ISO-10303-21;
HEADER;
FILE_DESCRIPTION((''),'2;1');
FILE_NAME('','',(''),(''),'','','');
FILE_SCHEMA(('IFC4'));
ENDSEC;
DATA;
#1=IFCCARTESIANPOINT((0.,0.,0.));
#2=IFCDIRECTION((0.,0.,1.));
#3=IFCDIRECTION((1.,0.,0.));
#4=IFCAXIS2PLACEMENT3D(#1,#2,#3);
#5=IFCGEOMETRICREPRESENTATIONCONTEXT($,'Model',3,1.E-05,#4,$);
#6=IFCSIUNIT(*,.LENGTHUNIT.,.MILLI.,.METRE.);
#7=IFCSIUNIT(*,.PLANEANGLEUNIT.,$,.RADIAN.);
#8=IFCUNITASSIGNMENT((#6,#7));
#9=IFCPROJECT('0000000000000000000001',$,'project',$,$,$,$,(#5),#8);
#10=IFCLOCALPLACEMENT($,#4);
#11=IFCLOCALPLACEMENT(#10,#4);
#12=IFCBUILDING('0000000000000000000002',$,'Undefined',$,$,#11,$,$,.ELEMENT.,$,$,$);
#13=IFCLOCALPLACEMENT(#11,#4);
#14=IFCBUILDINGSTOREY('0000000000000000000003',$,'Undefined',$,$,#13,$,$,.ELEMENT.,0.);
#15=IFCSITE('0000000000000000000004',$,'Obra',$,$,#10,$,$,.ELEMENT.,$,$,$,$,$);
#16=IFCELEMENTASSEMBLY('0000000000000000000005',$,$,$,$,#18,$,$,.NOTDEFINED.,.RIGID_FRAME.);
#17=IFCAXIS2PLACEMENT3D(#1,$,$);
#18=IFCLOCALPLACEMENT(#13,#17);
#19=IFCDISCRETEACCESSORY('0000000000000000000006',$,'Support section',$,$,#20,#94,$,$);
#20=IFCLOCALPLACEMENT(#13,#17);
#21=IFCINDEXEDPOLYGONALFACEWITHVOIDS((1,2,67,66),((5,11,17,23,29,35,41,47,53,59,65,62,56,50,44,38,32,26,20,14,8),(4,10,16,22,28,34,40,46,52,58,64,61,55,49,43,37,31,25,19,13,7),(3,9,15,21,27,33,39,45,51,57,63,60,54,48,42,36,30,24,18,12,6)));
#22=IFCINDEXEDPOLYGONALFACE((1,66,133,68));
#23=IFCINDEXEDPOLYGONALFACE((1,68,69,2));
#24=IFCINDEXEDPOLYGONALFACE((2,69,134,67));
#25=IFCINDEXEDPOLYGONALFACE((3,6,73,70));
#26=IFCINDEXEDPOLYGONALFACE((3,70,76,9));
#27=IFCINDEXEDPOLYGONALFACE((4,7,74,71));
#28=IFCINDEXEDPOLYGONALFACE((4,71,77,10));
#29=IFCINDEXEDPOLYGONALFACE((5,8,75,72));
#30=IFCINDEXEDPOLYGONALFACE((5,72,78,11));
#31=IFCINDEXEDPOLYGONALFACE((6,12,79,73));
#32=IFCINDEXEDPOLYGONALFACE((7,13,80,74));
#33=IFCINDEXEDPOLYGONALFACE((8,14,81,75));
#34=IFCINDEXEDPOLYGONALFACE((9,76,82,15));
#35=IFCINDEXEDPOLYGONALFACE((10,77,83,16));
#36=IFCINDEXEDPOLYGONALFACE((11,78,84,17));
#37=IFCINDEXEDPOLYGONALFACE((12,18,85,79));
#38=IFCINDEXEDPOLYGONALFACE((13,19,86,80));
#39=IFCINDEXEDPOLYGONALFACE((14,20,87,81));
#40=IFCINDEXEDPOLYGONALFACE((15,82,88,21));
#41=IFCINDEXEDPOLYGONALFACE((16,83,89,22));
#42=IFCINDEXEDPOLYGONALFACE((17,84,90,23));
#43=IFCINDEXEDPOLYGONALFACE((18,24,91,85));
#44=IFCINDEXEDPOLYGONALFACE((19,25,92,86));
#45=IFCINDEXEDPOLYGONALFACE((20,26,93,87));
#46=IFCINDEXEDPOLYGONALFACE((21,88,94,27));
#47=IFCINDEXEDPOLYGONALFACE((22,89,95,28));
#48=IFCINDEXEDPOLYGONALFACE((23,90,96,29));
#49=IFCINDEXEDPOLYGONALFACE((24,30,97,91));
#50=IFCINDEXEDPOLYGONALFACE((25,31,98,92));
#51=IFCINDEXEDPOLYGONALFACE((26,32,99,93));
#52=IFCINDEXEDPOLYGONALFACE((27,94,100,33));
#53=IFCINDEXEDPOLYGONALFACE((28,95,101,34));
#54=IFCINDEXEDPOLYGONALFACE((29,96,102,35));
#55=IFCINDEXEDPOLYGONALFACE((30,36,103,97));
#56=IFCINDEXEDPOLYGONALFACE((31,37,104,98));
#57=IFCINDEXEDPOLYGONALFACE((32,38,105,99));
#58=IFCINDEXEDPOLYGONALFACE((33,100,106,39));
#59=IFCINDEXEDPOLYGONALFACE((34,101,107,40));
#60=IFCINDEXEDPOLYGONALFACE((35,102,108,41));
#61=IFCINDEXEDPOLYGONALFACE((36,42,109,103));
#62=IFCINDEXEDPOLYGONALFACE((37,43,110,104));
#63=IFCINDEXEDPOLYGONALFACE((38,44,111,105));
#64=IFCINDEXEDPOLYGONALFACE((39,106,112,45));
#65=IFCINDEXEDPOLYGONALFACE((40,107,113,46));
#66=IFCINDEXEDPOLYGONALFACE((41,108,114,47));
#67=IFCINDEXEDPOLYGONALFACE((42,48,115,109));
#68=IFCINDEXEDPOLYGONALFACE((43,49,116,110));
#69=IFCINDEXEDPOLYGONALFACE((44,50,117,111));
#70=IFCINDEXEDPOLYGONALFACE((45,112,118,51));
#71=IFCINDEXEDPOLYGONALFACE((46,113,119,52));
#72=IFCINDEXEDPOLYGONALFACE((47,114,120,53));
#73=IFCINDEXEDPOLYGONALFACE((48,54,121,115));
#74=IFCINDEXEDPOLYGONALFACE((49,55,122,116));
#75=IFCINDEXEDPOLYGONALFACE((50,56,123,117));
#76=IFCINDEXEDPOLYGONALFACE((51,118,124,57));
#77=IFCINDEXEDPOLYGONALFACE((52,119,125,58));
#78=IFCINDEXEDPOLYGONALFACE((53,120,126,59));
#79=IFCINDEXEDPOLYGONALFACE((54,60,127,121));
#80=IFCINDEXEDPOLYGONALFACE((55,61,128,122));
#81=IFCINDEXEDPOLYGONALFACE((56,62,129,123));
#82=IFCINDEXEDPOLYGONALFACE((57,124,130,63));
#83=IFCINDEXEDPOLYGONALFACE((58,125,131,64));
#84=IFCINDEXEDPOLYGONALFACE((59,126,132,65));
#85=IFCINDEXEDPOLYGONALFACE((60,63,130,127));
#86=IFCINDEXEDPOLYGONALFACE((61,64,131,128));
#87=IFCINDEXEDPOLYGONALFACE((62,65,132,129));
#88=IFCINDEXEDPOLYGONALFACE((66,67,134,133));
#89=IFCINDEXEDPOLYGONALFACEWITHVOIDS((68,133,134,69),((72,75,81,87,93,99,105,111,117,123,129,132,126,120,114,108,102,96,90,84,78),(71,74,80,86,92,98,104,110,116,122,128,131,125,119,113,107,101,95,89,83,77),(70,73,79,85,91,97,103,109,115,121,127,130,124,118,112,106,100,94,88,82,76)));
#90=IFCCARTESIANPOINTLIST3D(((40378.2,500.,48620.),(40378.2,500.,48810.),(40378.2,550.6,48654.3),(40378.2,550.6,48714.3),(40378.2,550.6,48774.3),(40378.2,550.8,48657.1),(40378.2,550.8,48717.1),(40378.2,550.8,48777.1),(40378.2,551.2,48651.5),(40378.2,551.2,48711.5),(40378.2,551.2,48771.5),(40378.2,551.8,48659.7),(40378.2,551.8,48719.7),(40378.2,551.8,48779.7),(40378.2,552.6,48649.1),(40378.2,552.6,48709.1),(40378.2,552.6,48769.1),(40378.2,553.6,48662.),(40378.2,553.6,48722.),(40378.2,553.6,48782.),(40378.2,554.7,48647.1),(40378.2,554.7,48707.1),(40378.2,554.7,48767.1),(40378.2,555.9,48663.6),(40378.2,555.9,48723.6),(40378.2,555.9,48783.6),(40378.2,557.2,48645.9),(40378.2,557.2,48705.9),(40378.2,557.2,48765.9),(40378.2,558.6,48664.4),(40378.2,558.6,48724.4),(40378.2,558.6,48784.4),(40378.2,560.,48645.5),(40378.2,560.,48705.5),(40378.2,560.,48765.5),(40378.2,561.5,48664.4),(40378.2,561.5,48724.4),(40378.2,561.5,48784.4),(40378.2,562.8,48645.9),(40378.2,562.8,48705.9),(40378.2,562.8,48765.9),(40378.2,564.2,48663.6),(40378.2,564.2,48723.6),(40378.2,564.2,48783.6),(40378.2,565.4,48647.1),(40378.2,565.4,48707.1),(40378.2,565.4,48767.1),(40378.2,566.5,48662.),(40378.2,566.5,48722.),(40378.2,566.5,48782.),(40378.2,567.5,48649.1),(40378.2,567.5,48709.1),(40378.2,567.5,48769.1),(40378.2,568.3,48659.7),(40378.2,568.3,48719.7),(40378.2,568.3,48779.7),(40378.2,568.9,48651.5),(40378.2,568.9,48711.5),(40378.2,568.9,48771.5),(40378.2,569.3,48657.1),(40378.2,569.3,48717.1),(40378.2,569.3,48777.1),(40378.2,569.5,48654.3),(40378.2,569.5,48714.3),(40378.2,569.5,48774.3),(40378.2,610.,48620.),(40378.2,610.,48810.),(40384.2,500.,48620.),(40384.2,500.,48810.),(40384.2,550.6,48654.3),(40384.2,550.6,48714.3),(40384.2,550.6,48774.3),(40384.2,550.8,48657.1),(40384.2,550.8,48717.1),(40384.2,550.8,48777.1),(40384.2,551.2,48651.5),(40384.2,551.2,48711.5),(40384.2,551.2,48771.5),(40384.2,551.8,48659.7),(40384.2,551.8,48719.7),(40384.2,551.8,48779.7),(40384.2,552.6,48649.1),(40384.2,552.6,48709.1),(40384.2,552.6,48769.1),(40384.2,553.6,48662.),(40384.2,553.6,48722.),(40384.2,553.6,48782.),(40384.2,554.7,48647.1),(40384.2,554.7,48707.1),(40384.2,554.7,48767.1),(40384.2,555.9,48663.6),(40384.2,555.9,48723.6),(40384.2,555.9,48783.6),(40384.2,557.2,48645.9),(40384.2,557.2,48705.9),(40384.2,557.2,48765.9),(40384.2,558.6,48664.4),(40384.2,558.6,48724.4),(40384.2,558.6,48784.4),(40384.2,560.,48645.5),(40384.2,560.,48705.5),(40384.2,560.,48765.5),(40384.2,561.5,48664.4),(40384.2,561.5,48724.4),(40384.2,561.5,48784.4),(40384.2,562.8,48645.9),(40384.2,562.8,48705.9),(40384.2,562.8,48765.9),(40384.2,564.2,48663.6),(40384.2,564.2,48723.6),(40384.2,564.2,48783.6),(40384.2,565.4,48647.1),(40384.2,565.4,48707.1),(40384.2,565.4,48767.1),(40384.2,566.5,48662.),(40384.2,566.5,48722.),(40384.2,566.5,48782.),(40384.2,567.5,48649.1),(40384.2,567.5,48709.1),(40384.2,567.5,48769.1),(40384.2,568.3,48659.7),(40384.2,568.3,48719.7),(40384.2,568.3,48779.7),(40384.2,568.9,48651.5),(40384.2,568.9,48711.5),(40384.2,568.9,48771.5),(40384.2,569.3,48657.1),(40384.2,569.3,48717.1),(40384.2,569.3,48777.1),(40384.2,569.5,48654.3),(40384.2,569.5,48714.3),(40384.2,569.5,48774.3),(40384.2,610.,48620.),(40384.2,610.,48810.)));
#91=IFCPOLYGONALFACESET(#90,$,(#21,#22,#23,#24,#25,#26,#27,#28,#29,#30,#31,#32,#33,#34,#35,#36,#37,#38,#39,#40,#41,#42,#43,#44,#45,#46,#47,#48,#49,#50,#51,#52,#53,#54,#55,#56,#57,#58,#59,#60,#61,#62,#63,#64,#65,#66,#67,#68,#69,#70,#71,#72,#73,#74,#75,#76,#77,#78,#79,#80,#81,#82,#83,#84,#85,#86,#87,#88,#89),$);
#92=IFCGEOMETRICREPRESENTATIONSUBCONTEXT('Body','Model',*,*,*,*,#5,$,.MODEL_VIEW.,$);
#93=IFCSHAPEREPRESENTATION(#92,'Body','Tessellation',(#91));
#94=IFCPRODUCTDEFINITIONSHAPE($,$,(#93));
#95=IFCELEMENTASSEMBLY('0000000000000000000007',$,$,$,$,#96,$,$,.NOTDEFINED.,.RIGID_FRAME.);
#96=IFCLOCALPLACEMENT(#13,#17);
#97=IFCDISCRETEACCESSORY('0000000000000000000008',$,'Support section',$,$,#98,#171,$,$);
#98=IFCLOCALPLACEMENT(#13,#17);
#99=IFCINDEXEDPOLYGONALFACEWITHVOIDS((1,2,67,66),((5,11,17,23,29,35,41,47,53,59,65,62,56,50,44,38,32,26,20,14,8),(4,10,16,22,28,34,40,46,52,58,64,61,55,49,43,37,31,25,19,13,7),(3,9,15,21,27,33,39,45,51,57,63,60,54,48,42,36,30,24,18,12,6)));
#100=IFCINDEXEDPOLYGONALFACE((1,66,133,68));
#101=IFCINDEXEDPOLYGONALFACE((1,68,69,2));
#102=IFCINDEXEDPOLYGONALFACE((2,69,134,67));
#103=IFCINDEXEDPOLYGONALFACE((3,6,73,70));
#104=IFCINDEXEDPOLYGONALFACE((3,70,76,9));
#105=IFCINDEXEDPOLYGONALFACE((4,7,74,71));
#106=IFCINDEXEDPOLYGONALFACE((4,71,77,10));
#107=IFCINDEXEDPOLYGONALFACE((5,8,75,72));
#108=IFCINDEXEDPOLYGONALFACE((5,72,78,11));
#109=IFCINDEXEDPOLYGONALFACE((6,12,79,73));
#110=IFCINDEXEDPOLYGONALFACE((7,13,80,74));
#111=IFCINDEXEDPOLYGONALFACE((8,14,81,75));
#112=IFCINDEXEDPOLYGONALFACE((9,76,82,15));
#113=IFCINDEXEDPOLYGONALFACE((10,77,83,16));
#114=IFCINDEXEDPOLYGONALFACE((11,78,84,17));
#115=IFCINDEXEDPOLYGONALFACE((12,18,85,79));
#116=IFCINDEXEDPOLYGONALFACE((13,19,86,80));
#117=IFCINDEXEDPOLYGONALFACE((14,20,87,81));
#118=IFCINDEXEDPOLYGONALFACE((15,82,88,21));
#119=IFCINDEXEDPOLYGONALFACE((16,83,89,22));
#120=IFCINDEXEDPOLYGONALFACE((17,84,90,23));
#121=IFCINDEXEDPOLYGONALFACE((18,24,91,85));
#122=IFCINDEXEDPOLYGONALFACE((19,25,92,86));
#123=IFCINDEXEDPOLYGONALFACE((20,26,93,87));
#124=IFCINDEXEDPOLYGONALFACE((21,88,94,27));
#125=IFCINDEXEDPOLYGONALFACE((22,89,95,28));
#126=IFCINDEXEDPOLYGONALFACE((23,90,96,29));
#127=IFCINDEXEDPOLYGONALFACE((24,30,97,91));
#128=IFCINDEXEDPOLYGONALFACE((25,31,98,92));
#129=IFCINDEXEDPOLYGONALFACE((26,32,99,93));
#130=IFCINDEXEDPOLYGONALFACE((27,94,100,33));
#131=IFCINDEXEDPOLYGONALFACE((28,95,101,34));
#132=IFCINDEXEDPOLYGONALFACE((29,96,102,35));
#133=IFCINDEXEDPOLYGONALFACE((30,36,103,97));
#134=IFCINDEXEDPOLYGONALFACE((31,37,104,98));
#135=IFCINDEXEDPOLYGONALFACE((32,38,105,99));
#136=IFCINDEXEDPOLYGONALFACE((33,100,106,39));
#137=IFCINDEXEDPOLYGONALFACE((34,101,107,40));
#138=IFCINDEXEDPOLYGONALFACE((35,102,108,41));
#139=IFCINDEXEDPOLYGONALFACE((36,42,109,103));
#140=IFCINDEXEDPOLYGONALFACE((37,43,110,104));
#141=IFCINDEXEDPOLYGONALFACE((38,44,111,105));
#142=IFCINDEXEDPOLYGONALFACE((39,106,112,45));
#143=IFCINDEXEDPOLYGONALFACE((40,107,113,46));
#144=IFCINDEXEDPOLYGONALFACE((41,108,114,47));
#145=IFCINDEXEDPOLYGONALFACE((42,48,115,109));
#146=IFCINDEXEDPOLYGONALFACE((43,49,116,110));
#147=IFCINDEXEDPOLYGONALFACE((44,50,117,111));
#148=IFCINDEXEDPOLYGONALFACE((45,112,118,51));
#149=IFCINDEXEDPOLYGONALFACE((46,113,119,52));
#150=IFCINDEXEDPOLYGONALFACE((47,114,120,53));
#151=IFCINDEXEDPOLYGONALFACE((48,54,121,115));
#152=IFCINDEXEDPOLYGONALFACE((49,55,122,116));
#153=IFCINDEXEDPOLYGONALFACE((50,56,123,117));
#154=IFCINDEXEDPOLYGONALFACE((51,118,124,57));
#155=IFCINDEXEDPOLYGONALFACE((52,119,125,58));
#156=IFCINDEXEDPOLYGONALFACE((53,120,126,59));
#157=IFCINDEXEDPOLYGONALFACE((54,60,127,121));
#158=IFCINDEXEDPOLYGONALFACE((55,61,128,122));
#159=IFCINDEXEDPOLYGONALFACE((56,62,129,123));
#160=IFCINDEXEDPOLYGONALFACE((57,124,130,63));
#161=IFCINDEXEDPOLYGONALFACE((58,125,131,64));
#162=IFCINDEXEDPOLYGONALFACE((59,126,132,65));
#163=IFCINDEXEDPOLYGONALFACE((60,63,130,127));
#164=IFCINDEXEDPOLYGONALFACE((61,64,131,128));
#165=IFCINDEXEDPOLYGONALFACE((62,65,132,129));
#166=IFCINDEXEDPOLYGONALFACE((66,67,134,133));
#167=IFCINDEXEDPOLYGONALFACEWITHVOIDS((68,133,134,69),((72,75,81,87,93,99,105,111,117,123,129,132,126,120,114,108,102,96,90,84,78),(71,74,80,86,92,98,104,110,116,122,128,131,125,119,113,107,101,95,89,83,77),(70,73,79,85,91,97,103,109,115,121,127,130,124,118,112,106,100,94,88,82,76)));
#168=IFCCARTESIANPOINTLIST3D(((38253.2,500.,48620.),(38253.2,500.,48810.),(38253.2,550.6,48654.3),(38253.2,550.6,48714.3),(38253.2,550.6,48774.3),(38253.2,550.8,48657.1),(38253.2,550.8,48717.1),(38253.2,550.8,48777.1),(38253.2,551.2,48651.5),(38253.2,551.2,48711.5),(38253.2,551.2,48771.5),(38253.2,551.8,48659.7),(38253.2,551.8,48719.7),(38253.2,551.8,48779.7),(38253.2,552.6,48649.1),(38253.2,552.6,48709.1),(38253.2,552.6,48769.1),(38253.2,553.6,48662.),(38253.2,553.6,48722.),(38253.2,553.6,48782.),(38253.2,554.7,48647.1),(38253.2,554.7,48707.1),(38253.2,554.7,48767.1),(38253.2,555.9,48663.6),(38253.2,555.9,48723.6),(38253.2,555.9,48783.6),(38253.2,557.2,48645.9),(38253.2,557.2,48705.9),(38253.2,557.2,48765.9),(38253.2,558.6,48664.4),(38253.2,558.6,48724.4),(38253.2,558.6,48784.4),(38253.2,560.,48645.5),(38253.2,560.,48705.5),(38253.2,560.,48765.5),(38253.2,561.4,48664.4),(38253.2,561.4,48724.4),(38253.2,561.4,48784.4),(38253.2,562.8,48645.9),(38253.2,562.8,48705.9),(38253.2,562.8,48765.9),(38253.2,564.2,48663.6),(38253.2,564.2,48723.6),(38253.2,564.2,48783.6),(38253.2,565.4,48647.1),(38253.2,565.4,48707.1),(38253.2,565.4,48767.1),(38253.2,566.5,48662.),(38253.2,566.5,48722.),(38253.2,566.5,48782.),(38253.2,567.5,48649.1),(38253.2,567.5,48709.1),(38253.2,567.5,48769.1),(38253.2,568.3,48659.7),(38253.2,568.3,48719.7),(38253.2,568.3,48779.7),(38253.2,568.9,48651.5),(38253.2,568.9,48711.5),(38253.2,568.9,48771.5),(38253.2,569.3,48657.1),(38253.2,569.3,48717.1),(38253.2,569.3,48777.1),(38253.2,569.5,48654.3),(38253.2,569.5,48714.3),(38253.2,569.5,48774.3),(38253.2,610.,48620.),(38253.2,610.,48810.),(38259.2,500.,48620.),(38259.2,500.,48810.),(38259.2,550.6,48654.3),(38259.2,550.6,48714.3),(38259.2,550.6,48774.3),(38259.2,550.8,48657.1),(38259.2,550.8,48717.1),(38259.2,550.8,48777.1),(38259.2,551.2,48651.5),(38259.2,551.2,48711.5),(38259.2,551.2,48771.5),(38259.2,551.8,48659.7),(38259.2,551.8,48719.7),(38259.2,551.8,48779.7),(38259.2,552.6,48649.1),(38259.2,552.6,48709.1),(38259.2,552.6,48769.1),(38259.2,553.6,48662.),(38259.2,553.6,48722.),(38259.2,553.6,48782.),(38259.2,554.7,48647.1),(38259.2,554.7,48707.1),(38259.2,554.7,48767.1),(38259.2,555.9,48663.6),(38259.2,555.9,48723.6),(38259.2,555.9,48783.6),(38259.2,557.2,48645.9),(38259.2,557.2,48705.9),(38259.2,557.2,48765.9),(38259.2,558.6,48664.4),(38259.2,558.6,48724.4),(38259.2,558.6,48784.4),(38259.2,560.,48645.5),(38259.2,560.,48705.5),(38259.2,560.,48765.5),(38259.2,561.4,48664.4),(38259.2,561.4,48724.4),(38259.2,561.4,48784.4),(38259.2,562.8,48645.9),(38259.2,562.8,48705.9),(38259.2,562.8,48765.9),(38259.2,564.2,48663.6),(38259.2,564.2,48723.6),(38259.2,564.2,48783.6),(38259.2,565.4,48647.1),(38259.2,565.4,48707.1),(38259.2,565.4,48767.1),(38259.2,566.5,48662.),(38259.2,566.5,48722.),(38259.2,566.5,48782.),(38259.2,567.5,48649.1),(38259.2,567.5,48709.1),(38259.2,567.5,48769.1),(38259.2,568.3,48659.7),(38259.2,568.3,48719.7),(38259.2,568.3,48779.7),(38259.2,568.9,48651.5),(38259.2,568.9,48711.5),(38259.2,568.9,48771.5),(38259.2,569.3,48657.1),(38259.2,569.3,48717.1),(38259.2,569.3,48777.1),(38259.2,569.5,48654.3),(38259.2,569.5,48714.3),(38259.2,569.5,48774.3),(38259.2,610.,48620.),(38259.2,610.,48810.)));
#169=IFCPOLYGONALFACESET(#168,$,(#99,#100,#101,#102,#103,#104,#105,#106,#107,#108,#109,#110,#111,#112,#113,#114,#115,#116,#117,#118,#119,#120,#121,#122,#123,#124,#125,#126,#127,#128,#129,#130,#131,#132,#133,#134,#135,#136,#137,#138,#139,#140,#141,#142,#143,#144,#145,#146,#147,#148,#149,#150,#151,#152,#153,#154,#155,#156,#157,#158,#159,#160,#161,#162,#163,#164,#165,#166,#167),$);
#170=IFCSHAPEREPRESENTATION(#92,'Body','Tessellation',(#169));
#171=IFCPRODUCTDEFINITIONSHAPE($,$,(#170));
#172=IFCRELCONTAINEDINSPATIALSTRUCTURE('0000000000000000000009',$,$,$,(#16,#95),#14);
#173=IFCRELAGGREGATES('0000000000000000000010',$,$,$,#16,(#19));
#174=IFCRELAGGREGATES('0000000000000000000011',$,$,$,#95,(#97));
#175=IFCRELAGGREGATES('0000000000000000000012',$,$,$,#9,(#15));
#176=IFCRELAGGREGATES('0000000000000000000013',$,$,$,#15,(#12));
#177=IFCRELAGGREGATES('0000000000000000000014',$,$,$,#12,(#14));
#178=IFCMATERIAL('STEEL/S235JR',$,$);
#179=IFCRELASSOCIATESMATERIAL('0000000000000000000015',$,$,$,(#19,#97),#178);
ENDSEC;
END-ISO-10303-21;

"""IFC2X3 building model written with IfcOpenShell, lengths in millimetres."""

from ifc_helpers import new_model, si_unit, frame, origin_with_axes, origin_2d_with_axis, place, context, subcontext, project, spatial, rectangle, circle, extrude, source, transform, mapped, material, element, aggregate, save


model = new_model("IFC2X3")

# Units and contexts
model_context = context("Model", 3, precision=1e-05, world=origin_with_axes())
body_context = subcontext(model_context, "Body", "Model", "MODEL_VIEW")
ifc_project = project(units=[si_unit("LENGTHUNIT", "METRE", prefix="MILLI"), si_unit("PLANEANGLEUNIT", "RADIAN")], contexts=[model_context])

# Site, building, storey
site_placement = place(None, origin_with_axes())
site = spatial("IfcSite", under=ifc_project, at=site_placement, Name="Obra", CompositionType="ELEMENT")
building_placement = place(site_placement, origin_with_axes())
building = spatial("IfcBuilding", under=site, at=building_placement, Name="Undefined", CompositionType="ELEMENT")
storey_placement = place(building_placement, origin_with_axes())
storey = spatial("IfcBuildingStorey", under=building, at=storey_placement, Name="Undefined", CompositionType="ELEMENT", Elevation=0.0)

# Element assembly
ifc_material_1 = material(Name="STEEL/S235JR")
assembly_1_placement = place(storey_placement, origin_with_axes())
assembly_1 = element("IfcElementAssembly", 1, at=assembly_1_placement, inside=storey, AssemblyPlace="NOTDEFINED", PredefinedType="RIGID_FRAME")

# Discrete accessory, opening
shared_shape_1 = source(origin_with_axes(), body_context, "Body", "SweptSolid", [
    extrude(circle(Radius=9.5, at=origin_2d_with_axis()), frame((0.0, -9.2, 0.0), z_axis=(0.0, 1.0, 0.0), x_axis=(1.0, 0.0, 0.0)), (0.0, 0.0, 1.0), 6.2),
])
discrete_accessory_1_placement = place(assembly_1_placement, frame((40381.2, 555.0, 48620.0), z_axis=(0.0, 0.0, 1.0), x_axis=(0.000002, -1.0, 0.0)))
discrete_accessory_1 = element("IfcDiscreteAccessory", 2, at=discrete_accessory_1_placement, material=ifc_material_1, Name="Support section", context=body_context, shape_type="SweptSolid", body=[
    extrude(rectangle(XDim=6.0, YDim=110.0, at=origin_2d_with_axis()), frame((0.0, 0.0, 190.0), z_axis=(0.0, 0.0, -1.0), x_axis=(0.0, 1.0, 0.0)), (0.0, 0.0, 1.0), 190.0),
])
opening_1_placement = place(assembly_1_placement, frame((40375.1, 510.0, 48835.0), z_axis=(-0.000002, 1.0, 0.0), x_axis=(0.0, 0.0, -1.0)))
element("IfcOpeningElement", 3, at=opening_1_placement, cuts=discrete_accessory_1, ObjectType="Opening", context=body_context, shape_type="MappedRepresentation", body=[
    mapped(shared_shape_1, transform((60.0, 0.0, 50.0))),
    mapped(shared_shape_1, transform((120.0, 0.0, 50.0))),
    mapped(shared_shape_1, transform((180.0, 0.0, 50.0))),
])
aggregate(assembly_1, [discrete_accessory_1])

# Element assembly, discrete accessory, opening
assembly_2_placement = place(storey_placement, origin_with_axes())
assembly_2 = element("IfcElementAssembly", 4, at=assembly_2_placement, inside=storey, AssemblyPlace="NOTDEFINED", PredefinedType="RIGID_FRAME")
discrete_accessory_2_placement = place(assembly_2_placement, frame((38256.2, 555.0, 48620.0), z_axis=(0.0, 0.0, 1.0), x_axis=(0.000002, -1.0, 0.0)))
discrete_accessory_2 = element("IfcDiscreteAccessory", 5, at=discrete_accessory_2_placement, material=ifc_material_1, Name="Support section", context=body_context, shape_type="SweptSolid", body=[
    extrude(rectangle(XDim=6.0, YDim=110.0, at=origin_2d_with_axis()), frame((0.0, 0.0, 190.0), z_axis=(0.0, 0.0, -1.0), x_axis=(0.0, 1.0, 0.0)), (0.0, 0.0, 1.0), 190.0),
])
opening_2_placement = place(assembly_2_placement, frame((38250.1, 510.0, 48835.0), z_axis=(-0.000002, 1.0, 0.0), x_axis=(0.0, 0.0, -1.0)))
element("IfcOpeningElement", 6, at=opening_2_placement, cuts=discrete_accessory_2, ObjectType="Opening", context=body_context, shape_type="MappedRepresentation", body=[
    mapped(shared_shape_1, transform((60.0, 0.0, 50.0))),
    mapped(shared_shape_1, transform((120.0, 0.0, 50.0))),
    mapped(shared_shape_1, transform((180.0, 0.0, 50.0))),
])
aggregate(assembly_2, [discrete_accessory_2])

save(model, "model.ifc")
